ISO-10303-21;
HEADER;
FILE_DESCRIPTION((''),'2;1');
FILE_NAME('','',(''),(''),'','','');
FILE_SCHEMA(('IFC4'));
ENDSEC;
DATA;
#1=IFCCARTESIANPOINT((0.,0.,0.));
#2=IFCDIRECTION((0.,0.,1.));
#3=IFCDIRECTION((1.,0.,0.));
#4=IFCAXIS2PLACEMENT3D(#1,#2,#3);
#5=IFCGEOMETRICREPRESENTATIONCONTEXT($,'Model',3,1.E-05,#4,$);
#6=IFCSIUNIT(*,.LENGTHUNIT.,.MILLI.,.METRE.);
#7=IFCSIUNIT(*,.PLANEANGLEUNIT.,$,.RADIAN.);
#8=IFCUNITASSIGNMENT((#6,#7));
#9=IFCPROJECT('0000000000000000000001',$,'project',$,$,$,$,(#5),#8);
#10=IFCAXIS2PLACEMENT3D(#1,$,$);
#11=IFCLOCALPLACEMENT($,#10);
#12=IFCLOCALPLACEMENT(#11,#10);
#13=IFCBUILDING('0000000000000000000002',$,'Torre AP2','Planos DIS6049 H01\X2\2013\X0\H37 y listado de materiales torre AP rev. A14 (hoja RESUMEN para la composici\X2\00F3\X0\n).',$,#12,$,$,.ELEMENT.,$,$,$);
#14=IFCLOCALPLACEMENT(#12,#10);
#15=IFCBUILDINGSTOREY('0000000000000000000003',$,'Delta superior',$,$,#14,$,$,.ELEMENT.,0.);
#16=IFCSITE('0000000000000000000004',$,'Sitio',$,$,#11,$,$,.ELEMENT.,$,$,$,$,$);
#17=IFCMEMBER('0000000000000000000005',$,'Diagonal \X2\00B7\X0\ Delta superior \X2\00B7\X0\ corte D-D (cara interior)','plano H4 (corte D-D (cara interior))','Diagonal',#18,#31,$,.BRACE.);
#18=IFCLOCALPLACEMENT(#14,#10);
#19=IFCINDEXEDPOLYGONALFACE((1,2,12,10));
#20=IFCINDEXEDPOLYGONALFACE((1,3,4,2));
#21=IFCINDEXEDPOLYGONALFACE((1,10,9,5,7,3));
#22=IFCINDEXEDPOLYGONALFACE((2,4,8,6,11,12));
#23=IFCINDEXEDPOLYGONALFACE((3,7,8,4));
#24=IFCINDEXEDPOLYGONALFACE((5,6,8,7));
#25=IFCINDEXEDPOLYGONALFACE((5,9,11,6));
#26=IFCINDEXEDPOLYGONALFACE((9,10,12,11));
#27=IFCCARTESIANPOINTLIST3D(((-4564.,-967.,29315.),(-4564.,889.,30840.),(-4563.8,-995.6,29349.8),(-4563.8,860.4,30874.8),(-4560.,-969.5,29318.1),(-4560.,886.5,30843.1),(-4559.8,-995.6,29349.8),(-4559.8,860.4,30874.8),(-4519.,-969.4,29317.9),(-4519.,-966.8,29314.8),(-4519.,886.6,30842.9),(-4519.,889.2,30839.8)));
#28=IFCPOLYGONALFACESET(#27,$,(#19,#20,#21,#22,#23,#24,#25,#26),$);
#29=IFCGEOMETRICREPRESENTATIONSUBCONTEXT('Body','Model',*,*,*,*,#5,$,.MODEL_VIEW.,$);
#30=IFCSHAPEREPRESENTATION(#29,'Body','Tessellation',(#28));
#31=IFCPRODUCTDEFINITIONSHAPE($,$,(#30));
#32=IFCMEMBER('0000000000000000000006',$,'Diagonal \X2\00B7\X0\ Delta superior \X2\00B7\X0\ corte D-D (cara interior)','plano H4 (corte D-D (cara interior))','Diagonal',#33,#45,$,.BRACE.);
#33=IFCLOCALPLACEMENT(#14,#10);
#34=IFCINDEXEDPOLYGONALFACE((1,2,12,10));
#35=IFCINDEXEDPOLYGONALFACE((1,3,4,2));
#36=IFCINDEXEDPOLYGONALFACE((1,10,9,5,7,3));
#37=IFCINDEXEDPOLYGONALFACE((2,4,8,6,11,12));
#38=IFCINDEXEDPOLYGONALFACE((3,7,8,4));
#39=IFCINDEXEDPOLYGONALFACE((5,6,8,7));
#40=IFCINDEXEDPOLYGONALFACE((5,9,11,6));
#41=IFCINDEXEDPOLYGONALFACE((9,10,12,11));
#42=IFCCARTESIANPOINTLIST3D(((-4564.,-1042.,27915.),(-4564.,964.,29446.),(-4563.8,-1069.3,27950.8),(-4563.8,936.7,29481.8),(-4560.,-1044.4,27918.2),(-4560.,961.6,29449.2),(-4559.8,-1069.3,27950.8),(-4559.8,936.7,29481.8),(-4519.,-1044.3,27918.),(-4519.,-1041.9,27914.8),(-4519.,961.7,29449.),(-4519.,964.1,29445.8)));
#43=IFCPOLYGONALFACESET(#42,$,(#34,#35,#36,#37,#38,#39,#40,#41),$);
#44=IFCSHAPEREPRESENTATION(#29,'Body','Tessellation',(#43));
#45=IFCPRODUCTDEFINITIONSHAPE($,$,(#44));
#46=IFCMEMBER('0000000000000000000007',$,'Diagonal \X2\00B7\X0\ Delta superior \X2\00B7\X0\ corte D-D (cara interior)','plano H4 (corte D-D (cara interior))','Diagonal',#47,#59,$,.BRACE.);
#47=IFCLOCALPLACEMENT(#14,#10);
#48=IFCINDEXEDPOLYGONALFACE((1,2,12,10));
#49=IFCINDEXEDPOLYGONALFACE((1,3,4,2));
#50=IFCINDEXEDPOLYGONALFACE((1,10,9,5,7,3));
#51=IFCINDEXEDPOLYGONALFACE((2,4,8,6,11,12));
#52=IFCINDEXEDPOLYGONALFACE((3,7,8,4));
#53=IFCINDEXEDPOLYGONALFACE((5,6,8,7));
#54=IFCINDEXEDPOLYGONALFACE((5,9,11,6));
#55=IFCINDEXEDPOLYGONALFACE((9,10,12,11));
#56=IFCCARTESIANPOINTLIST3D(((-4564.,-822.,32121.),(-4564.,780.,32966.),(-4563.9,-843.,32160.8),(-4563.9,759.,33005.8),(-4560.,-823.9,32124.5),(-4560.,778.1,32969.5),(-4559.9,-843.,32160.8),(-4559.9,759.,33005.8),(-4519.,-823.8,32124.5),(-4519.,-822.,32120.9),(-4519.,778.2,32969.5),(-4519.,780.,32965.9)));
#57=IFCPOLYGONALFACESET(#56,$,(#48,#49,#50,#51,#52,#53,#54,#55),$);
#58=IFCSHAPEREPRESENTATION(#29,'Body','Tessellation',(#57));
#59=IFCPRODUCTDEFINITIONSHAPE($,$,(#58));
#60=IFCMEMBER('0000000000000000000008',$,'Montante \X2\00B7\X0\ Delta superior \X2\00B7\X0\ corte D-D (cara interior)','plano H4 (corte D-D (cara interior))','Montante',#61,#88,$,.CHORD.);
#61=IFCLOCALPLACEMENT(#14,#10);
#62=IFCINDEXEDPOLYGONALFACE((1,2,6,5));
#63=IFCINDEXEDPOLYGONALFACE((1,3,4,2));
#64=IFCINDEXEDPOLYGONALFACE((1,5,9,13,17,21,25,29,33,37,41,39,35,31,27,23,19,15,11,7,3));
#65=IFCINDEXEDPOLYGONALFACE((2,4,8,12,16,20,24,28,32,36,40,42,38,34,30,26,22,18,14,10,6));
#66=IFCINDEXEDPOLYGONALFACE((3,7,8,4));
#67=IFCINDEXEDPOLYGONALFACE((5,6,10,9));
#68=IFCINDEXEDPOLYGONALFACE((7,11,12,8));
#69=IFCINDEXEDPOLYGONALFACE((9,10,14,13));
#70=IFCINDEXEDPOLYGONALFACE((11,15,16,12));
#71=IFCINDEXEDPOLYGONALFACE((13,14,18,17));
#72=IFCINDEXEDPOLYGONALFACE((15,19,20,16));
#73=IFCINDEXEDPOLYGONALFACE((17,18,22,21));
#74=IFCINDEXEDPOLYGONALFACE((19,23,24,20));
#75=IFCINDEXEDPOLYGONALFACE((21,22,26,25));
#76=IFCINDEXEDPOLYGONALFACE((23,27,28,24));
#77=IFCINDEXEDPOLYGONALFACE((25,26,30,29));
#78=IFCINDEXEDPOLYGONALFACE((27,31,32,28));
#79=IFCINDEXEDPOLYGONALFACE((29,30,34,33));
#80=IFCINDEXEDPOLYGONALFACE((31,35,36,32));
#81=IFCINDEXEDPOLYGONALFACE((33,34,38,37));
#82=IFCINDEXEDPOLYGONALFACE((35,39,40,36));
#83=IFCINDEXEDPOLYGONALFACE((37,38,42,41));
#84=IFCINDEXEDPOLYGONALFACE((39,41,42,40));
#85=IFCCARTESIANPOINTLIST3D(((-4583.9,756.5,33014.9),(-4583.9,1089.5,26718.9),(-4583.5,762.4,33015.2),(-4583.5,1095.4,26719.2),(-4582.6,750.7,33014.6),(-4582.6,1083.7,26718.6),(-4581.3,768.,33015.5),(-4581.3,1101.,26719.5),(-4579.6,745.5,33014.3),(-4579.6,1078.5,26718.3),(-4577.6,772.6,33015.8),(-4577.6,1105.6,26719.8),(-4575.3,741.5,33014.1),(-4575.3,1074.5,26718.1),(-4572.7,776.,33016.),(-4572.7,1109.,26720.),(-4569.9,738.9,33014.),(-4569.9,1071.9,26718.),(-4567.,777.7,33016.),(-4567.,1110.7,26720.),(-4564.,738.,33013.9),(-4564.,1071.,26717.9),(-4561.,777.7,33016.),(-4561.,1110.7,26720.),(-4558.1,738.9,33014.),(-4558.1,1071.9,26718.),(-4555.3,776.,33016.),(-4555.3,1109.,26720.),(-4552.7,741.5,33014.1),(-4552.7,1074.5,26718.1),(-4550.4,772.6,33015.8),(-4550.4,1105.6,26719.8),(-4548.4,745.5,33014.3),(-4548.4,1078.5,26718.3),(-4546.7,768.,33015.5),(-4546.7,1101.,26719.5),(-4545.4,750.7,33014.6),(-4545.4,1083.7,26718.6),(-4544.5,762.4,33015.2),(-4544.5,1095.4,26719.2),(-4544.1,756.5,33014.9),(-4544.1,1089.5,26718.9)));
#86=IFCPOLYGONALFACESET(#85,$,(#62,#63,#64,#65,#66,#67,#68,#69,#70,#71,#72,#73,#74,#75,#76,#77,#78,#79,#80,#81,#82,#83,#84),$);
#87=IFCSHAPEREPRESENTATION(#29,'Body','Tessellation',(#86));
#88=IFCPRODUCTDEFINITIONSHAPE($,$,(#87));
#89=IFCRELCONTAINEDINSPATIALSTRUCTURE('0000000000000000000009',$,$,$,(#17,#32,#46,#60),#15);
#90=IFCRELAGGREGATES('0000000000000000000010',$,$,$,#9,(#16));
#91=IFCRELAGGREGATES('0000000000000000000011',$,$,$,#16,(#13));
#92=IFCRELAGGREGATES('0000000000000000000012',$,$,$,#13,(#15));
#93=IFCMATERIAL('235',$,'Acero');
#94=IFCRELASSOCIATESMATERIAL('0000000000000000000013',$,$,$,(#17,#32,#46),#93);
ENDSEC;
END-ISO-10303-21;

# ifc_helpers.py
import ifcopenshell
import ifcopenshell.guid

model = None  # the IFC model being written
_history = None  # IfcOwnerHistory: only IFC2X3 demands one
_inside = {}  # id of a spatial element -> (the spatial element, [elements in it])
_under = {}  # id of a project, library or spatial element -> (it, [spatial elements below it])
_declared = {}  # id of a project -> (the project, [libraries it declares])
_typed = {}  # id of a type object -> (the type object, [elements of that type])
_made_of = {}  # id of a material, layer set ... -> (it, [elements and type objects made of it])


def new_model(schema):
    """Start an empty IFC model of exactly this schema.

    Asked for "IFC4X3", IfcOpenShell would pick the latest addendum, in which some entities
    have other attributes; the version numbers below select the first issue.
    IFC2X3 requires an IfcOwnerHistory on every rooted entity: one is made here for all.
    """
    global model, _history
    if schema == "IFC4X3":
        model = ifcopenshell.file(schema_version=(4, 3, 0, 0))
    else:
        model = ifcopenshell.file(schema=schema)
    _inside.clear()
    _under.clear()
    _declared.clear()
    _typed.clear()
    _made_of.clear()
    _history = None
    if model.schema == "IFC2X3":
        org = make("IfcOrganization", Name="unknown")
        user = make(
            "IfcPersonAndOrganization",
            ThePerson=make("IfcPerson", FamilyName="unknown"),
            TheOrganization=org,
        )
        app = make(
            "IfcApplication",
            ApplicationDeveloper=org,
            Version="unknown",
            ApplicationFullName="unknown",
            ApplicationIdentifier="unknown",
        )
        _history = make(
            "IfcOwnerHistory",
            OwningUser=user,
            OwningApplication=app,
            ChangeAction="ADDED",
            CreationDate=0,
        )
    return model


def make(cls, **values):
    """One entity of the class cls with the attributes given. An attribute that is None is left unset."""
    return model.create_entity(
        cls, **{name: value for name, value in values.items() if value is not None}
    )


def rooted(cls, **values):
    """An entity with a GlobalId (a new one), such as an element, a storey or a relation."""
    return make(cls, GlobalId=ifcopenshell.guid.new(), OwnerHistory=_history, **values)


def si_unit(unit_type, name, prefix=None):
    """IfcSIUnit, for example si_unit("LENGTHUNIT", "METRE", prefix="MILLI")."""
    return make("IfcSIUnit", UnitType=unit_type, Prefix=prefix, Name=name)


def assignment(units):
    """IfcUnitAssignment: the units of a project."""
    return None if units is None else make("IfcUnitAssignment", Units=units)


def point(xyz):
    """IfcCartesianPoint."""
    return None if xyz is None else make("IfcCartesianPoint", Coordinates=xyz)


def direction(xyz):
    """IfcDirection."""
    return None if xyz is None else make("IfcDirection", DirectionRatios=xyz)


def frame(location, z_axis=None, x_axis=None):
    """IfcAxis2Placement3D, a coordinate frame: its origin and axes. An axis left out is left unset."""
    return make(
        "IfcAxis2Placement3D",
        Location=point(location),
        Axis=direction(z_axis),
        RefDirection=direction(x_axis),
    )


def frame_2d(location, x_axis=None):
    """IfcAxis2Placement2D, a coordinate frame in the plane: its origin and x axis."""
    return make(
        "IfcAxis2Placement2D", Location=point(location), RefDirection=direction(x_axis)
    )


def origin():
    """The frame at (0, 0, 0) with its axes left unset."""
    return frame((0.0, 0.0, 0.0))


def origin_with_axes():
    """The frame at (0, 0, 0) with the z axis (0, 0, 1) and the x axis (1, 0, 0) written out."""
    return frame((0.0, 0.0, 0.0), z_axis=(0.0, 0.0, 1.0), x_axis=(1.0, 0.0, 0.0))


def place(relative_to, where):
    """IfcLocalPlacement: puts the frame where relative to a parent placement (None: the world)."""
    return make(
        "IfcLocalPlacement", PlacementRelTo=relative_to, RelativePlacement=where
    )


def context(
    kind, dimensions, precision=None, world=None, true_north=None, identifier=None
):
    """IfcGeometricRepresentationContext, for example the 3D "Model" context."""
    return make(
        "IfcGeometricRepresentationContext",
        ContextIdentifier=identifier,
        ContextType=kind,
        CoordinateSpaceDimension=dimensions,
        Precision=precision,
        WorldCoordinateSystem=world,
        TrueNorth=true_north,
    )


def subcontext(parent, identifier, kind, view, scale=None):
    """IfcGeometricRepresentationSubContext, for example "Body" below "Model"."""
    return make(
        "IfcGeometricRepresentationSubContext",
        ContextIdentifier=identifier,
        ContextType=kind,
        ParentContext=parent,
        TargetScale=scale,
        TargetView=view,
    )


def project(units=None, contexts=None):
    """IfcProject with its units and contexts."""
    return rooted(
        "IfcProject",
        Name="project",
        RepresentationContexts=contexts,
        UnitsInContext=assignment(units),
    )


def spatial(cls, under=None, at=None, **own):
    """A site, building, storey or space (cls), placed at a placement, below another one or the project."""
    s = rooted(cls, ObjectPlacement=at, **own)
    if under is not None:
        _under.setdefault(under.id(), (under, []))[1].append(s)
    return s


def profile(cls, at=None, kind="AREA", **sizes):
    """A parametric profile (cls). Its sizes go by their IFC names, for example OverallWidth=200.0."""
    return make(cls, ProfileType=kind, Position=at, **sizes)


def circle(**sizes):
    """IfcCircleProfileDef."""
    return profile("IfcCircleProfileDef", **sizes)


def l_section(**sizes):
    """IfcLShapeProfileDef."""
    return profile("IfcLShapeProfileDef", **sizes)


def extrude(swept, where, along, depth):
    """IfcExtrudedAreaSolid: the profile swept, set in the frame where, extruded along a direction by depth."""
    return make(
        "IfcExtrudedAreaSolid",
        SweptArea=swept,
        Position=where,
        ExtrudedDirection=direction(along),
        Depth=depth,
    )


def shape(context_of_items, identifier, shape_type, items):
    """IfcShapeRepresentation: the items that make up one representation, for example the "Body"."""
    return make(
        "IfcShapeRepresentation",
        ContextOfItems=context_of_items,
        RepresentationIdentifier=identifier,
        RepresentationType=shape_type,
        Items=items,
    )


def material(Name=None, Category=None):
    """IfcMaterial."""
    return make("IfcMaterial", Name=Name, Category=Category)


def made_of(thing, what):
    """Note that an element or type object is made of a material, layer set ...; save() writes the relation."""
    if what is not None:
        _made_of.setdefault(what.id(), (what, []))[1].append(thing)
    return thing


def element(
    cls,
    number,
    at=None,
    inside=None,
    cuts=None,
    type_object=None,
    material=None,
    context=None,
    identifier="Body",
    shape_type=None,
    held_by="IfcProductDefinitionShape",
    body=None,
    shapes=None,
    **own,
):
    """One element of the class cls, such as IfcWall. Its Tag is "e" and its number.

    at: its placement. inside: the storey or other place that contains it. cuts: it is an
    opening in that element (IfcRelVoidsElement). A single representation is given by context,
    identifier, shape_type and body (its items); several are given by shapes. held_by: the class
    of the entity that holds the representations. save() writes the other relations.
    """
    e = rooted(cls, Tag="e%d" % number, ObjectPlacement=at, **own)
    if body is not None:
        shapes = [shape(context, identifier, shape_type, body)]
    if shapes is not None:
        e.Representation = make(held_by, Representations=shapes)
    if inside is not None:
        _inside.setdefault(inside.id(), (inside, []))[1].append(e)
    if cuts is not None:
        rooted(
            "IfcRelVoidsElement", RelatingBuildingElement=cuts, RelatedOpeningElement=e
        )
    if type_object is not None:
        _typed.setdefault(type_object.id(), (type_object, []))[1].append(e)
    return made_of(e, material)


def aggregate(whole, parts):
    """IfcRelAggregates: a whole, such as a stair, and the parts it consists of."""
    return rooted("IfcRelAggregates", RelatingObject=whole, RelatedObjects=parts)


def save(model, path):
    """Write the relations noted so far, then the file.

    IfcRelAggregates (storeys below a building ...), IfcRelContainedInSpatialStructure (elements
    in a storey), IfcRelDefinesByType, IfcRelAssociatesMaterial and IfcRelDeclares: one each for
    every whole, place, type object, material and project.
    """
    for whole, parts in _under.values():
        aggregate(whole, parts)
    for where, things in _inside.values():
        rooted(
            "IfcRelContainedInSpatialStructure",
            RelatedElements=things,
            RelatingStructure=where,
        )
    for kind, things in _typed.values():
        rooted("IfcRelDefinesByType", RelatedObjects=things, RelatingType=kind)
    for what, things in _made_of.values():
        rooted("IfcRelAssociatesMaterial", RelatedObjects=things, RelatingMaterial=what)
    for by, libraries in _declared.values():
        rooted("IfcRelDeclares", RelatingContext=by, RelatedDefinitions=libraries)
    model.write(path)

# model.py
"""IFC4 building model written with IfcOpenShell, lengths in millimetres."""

from ifc_helpers import new_model, si_unit, frame, frame_2d, origin, origin_with_axes, place, context, subcontext, project, spatial, circle, l_section, extrude, material, element, save


model = new_model("IFC4")

# Units and contexts
model_context = context("Model", 3, precision=1e-05, world=origin_with_axes())
body_context = subcontext(model_context, "Body", "Model", "MODEL_VIEW")
ifc_project = project(units=[si_unit("LENGTHUNIT", "METRE", prefix="MILLI"), si_unit("PLANEANGLEUNIT", "RADIAN")], contexts=[model_context])

# Site, building, storey
site_placement = place(None, origin())
site = spatial("IfcSite", under=ifc_project, at=site_placement, Name="Sitio", CompositionType="ELEMENT")
building_placement = place(site_placement, origin())
building = spatial("IfcBuilding", under=site, at=building_placement, Name="Torre AP2", Description="Planos DIS6049 H01–H37 y listado de materiales torre AP rev. A14 (hoja RESUMEN para la composición).", CompositionType="ELEMENT")
storey_placement = place(building_placement, origin())
storey = spatial("IfcBuildingStorey", under=building, at=storey_placement, Name="Delta superior", CompositionType="ELEMENT", Elevation=0.0)

# Members
ifc_material_1 = material(Name="235", Category="Acero")
member_1_placement = place(storey_placement, frame((-4564.0, 889.0, 30840.0), z_axis=(0.0, -0.772639, -0.634846), x_axis=(0.999985, 0.003444, -0.004191)))
element("IfcMember", 1, at=member_1_placement, inside=storey, material=ifc_material_1, Name="Diagonal · Delta superior · corte D-D (cara interior)", Description="plano H4 (corte D-D (cara interior))", ObjectType="Diagonal", PredefinedType="BRACE", context=body_context, shape_type="SweptSolid", body=[
    extrude(l_section(Depth=45.0, Width=45.0, Thickness=4.0, at=frame_2d((22.5, 22.5))), None, (0.0, 0.0, 1.0), 2402.2),
])
member_2_placement = place(storey_placement, frame((-4564.0, 964.0, 29446.0), z_axis=(0.0, -0.794931, -0.6067), x_axis=(0.999987, 0.003145, -0.004121)))
element("IfcMember", 2, at=member_2_placement, inside=storey, material=ifc_material_1, Name="Diagonal · Delta superior · corte D-D (cara interior)", Description="plano H4 (corte D-D (cara interior))", ObjectType="Diagonal", PredefinedType="BRACE", context=body_context, shape_type="SweptSolid", body=[
    extrude(l_section(Depth=45.0, Width=45.0, Thickness=4.0, at=frame_2d((22.5, 22.5))), None, (0.0, 0.0, 1.0), 2523.5),
])
member_3_placement = place(storey_placement, frame((-4564.0, 780.0, 32966.0), z_axis=(0.0, -0.884499, -0.466543), x_axis=(0.999998, 0.001002, -0.001899)))
element("IfcMember", 3, at=member_3_placement, inside=storey, material=ifc_material_1, Name="Diagonal · Delta superior · corte D-D (cara interior)", Description="plano H4 (corte D-D (cara interior))", ObjectType="Diagonal", PredefinedType="BRACE", context=body_context, shape_type="SweptSolid", body=[
    extrude(l_section(Depth=45.0, Width=45.0, Thickness=4.0, at=frame_2d((22.5, 22.5))), None, (0.0, 0.0, 1.0), 1811.2),
])
member_4_placement = place(storey_placement, frame((-4564.0, 1091.0, 26719.0), z_axis=(0.0, -0.052817, 0.998604), x_axis=(0.0, -0.998604, -0.052817)))
element("IfcMember", 4, at=member_4_placement, inside=storey, Name="Montante · Delta superior · corte D-D (cara interior)", Description="plano H4 (corte D-D (cara interior))", ObjectType="Montante", PredefinedType="CHORD", context=body_context, shape_type="SweptSolid", body=[
    extrude(circle(Radius=20.0), None, (0.0, 0.0, 1.0), 6304.8),
])

save(model, "model.ifc")
